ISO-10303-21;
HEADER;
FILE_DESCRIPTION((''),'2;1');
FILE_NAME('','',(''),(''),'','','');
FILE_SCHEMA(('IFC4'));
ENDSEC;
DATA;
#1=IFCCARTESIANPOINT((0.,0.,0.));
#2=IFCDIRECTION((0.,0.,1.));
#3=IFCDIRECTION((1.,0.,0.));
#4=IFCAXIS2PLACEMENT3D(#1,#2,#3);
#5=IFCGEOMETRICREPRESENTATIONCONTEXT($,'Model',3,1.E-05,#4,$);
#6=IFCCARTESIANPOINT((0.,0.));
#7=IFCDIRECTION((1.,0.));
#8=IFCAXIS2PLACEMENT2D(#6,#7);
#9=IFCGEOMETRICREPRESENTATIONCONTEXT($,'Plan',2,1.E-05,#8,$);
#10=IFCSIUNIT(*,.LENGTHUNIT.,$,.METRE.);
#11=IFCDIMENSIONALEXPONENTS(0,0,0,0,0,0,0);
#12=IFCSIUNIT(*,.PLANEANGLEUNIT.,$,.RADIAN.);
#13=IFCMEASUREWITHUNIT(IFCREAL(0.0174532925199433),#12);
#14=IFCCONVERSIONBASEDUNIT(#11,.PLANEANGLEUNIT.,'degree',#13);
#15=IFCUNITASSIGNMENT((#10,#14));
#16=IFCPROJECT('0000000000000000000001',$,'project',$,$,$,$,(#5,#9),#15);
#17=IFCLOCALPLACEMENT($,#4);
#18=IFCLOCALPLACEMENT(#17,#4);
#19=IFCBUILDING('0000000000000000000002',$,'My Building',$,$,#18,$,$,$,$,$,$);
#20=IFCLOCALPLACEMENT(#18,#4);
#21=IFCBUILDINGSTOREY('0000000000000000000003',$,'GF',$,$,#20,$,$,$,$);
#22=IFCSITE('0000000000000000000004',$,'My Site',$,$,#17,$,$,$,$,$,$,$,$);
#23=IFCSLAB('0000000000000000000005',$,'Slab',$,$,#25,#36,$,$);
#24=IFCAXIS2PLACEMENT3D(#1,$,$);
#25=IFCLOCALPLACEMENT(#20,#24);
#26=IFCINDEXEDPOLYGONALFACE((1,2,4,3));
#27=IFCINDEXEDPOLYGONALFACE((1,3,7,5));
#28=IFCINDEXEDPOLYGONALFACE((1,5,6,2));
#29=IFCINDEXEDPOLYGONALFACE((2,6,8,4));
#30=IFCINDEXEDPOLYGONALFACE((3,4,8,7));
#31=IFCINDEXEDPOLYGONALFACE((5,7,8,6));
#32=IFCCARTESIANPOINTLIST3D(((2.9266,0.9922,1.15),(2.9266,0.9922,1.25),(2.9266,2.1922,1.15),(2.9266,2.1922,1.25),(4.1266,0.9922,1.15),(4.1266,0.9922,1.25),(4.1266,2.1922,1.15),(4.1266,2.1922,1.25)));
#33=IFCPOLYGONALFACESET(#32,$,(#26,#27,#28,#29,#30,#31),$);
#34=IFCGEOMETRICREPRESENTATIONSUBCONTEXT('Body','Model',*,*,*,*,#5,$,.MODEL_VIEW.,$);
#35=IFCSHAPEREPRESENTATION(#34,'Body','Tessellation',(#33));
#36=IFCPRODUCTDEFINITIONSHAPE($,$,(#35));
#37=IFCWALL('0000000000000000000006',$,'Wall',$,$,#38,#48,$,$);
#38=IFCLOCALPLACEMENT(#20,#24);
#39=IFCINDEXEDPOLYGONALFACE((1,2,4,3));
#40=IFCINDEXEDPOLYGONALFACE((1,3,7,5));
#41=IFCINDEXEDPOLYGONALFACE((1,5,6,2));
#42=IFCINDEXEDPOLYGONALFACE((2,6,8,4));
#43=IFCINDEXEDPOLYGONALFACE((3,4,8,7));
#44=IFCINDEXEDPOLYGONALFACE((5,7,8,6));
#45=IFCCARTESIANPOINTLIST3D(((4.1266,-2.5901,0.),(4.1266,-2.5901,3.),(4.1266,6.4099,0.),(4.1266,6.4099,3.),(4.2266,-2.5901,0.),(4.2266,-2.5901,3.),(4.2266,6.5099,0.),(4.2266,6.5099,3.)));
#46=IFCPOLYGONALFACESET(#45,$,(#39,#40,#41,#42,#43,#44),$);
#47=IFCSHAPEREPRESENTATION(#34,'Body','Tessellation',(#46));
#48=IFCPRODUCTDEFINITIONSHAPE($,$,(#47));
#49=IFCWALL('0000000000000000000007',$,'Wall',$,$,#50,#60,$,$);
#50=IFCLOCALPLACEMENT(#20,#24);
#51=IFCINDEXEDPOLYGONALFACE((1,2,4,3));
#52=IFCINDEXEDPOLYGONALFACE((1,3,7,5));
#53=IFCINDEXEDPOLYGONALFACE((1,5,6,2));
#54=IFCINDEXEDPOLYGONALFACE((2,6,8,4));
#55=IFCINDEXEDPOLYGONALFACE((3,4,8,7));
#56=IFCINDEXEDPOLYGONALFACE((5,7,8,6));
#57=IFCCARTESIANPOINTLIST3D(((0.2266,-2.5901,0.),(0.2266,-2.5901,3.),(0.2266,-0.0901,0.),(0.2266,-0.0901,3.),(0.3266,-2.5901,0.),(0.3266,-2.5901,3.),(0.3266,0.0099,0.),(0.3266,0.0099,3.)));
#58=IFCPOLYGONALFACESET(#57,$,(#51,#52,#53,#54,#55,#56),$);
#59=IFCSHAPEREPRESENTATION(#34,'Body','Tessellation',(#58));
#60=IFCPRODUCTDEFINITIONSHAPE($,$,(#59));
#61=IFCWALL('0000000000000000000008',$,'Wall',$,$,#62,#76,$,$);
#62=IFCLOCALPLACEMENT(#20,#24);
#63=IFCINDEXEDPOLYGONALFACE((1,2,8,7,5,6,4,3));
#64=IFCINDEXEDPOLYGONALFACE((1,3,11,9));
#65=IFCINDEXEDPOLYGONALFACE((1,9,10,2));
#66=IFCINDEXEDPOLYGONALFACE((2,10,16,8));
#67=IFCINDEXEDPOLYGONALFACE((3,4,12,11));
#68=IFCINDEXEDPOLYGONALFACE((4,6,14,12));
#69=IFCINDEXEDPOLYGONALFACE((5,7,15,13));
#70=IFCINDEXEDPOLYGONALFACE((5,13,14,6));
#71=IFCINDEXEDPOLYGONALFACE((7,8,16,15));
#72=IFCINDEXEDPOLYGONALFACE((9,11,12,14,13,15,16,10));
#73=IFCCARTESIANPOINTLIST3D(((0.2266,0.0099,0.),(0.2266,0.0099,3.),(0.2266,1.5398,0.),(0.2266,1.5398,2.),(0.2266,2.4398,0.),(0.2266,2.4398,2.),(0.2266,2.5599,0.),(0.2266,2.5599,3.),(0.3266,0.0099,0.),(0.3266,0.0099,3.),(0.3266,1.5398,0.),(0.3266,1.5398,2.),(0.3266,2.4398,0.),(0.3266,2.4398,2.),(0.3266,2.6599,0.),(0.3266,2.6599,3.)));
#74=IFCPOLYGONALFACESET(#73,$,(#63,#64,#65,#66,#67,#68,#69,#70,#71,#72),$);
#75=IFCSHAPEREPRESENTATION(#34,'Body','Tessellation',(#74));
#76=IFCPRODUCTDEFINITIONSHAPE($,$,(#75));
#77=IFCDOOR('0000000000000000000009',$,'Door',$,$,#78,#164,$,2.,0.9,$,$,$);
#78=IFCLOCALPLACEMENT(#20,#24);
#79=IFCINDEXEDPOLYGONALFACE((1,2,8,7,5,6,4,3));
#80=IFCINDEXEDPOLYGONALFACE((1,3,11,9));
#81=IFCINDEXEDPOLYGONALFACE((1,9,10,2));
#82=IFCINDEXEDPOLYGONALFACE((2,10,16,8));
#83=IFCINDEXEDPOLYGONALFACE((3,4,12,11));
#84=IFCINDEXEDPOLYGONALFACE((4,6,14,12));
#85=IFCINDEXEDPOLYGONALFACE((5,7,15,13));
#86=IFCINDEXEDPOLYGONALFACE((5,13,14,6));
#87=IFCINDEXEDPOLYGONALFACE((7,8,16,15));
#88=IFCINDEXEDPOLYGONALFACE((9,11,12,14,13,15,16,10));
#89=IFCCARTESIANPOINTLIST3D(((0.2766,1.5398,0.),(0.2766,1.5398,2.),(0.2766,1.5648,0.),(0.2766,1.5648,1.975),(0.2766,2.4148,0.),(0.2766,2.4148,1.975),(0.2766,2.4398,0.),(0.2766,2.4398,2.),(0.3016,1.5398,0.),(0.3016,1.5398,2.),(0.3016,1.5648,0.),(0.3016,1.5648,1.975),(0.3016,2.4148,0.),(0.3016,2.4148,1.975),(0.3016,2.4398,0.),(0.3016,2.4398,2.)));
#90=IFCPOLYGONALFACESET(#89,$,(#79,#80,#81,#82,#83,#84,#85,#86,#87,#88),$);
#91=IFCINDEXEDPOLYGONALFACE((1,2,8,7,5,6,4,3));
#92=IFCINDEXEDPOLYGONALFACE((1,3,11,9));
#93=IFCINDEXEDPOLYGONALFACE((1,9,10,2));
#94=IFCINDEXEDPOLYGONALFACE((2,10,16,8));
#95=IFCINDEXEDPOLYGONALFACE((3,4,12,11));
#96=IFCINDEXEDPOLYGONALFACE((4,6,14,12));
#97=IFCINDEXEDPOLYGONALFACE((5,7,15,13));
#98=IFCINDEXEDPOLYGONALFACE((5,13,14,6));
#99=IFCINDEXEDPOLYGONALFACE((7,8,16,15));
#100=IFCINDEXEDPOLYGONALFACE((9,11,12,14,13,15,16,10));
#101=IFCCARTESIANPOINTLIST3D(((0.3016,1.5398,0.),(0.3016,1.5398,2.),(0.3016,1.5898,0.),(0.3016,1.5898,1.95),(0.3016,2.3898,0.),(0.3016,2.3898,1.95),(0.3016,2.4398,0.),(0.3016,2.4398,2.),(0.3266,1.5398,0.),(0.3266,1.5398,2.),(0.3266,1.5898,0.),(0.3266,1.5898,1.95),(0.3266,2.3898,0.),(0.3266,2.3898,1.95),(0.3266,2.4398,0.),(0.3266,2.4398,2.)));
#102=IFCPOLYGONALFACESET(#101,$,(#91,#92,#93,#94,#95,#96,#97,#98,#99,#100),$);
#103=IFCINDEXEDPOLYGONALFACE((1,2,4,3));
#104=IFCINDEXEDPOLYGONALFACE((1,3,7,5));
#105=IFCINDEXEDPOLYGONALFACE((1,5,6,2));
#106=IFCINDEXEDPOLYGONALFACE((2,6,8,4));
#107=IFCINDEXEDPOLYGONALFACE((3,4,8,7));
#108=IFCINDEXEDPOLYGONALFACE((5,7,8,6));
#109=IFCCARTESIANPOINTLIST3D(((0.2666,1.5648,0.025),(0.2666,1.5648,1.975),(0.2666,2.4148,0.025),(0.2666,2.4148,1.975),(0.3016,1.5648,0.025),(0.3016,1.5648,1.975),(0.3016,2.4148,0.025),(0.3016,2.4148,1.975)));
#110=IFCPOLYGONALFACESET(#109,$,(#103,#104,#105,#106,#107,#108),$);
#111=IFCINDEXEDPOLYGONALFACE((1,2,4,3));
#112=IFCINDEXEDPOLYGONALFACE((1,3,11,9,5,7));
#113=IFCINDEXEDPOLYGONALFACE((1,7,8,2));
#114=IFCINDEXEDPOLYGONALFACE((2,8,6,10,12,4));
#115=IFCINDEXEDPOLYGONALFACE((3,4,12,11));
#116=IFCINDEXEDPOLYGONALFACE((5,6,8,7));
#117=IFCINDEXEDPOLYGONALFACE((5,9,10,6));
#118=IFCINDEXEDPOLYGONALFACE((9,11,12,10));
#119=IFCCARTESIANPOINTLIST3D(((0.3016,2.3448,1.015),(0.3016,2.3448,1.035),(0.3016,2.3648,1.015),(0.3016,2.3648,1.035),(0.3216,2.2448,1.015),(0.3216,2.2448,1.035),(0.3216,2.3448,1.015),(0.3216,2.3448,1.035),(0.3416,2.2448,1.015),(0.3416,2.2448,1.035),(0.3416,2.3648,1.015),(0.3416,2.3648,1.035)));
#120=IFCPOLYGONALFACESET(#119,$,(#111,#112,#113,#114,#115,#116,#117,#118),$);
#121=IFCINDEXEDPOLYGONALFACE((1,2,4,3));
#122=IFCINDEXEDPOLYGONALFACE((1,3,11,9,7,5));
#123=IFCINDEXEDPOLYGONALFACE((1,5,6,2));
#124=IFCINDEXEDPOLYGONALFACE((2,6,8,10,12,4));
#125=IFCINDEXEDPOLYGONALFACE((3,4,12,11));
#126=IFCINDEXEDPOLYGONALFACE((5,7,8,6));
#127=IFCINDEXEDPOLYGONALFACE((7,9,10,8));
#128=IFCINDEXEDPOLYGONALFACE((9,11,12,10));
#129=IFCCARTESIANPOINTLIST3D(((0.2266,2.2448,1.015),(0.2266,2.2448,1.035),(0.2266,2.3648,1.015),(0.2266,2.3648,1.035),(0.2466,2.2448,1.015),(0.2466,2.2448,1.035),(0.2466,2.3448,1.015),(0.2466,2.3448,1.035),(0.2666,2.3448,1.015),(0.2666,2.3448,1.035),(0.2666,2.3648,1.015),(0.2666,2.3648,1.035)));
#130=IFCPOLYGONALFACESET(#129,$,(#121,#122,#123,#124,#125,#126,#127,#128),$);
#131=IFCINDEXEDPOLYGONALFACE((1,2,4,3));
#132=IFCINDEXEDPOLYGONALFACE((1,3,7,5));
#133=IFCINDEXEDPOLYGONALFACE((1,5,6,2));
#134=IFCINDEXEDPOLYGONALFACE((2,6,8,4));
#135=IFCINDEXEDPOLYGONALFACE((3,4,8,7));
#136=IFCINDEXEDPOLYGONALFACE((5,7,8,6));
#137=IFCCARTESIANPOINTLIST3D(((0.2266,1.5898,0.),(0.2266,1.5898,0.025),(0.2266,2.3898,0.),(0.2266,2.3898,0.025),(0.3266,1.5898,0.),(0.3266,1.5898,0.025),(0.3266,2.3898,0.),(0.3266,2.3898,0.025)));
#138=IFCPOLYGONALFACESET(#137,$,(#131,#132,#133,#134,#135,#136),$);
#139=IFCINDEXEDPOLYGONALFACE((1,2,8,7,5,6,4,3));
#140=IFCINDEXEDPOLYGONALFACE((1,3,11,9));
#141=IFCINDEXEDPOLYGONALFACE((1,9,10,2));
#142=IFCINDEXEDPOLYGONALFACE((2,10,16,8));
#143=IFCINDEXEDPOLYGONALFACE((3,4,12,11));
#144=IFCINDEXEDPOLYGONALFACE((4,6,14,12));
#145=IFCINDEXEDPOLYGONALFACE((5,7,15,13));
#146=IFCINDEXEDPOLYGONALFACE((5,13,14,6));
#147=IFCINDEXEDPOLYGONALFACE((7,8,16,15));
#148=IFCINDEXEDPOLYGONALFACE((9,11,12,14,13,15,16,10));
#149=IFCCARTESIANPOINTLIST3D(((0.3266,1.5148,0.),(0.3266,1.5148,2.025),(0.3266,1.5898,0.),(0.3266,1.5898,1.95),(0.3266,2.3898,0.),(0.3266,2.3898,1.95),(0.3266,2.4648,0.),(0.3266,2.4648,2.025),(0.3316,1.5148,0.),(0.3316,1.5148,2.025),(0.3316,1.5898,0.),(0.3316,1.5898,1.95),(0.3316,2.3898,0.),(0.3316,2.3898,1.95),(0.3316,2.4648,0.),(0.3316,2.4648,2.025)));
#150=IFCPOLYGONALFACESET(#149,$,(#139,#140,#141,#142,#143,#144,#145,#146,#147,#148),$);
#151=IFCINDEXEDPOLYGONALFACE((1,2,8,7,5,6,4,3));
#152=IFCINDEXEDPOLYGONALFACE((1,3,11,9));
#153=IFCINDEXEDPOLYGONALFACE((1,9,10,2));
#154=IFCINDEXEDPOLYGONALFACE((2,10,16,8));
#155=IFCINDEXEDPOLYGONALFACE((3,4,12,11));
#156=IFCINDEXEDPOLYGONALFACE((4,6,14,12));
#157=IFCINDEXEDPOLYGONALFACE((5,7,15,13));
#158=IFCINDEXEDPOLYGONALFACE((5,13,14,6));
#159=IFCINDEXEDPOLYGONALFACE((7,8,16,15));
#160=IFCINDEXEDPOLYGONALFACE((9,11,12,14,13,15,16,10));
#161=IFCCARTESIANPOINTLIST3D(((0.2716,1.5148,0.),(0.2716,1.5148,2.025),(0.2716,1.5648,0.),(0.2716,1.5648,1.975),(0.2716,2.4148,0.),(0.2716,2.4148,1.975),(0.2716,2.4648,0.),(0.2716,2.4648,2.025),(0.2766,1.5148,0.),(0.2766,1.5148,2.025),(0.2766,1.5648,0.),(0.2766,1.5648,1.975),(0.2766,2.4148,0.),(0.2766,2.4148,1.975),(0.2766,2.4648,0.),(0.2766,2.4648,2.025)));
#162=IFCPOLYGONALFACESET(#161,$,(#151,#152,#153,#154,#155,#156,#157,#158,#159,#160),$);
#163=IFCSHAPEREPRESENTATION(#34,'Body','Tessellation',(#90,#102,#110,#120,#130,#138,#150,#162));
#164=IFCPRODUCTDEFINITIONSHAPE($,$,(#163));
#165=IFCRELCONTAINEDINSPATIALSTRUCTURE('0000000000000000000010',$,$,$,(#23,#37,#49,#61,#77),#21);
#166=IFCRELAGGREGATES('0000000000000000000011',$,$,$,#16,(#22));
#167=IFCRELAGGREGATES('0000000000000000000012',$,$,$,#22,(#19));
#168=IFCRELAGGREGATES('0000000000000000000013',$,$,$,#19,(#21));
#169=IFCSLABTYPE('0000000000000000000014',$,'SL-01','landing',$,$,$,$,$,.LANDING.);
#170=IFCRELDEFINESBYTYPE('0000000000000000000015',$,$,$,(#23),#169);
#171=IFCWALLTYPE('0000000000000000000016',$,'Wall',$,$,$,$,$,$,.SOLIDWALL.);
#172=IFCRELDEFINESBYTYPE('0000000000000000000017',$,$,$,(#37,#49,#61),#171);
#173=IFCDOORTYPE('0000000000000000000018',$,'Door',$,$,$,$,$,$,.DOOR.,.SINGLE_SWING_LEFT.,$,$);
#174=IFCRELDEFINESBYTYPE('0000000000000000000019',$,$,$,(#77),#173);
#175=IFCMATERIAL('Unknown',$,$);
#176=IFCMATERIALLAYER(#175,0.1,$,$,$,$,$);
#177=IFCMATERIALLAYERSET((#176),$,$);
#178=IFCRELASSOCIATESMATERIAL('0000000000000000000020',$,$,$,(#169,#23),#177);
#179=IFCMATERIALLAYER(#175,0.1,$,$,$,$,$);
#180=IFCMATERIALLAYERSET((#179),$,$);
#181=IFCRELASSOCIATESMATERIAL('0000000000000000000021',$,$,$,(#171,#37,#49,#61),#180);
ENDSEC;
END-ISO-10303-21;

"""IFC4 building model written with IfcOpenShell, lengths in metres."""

from ifc_helpers import new_model, entity, si_unit, converted_unit, frame, origin_with_axes, origin_2d_with_axis, place, context, subcontext, project, spatial, line, indexed_curve, outline, extrude, shape, source, transform, mapped, material, layer, layer_set, layer_usage, type_object, type_shapes, element, fill, save


model = new_model("IFC4")

# Units and contexts
model_context = context("Model", 3, precision=1e-05, world=origin_with_axes())
plan_context = context("Plan", 2, precision=1e-05, world=origin_2d_with_axis())
body_context_1 = subcontext(model_context, "Body", "Model", "MODEL_VIEW")
body_context_2 = subcontext(plan_context, "Body", "Plan", "PLAN_VIEW")
ifc_project = project(units=[si_unit("LENGTHUNIT", "METRE"), converted_unit("PLANEANGLEUNIT", "degree", entity("IfcReal", 0.0174532925199433), si_unit("PLANEANGLEUNIT", "RADIAN"), dimensions=[0, 0, 0, 0, 0, 0, 0])], contexts=[model_context, plan_context])

# Site, building, storey
site_placement = place(None, origin_with_axes())
site = spatial("IfcSite", under=ifc_project, at=site_placement, Name="My Site")
building_placement = place(site_placement, origin_with_axes())
building = spatial("IfcBuilding", under=site, at=building_placement, Name="My Building")
storey_placement = place(building_placement, origin_with_axes())
storey = spatial("IfcBuildingStorey", under=building, at=storey_placement, Name="GF")

# Shared definitions
ifc_material = material(Name="Unknown")

# Slab
ifc_layer_1 = layer(ifc_material, 0.1)
ifc_layer_set_1 = layer_set([ifc_layer_1])
ifc_layer_usage_1 = layer_usage(ifc_layer_set_1, "AXIS3", "POSITIVE", -0.1)
slab_type_1 = type_object("IfcSlabType", Name="SL-01", Description="landing", PredefinedType="LANDING", material=ifc_layer_set_1)
slab_1_placement = place(storey_placement, frame((2.9266, 2.1922, 1.25), z_axis=(0.0, 0.0, 1.0), x_axis=(1.0, 0.0, 0.0)))
element("IfcSlab", 1, at=slab_1_placement, inside=storey, type_object=slab_type_1, material=ifc_layer_usage_1, Name="Slab", context=body_context_1, shape_type="SweptSolid", body=[
    extrude(outline(indexed_curve([(0.0, 0.0), (0.0, -1.2), (1.2, -1.2), (1.2, 0.0), (0.0, 0.0)])), frame((0.0, 0.0, -0.1), z_axis=(0.0, 0.0, 1.0), x_axis=(1.0, 0.0, 0.0)), (0.0, 0.0, 1.0), 0.1),
])

# Shared definitions
ifc_layer_2 = layer(ifc_material, 0.1)
ifc_layer_set_2 = layer_set([ifc_layer_2])
wall_type = type_object("IfcWallType", Name="Wall", PredefinedType="SOLIDWALL", material=ifc_layer_set_2)
shared_shape_1 = source(origin_with_axes(), body_context_1, "Body", "SweptSolid", [
    extrude(outline(indexed_curve([(0.0, 0.0), (0.9, 0.0), (0.9, 2.0), (0.0, 2.0)], segments=[line(1, 2, 3, 4, 1)])), frame((0.0, -0.6, 0.0), z_axis=(0.0, -1.0, 0.0), x_axis=(1.0, 0.0, 0.0)), (0.0, 0.0, -1.0), 1.2),
])
door_type = type_object("IfcDoorType", Name="Door", OperationType="SINGLE_SWING_LEFT", PredefinedType="DOOR")
shared_shape_2 = source(origin_with_axes(), body_context_1, "Body", "SweptSolid", [
    extrude(outline(indexed_curve([(0.0, 0.0), (0.0, 2.0), (0.9, 2.0), (0.9, 0.0), (0.875, 0.0), (0.875, 1.975), (0.025, 1.975), (0.025, 0.0)], segments=[line(1, 2, 3, 4, 5, 6, 7, 8, 1)])), frame((0.0, 0.025, 0.0), z_axis=(0.0, -1.0, 0.0), x_axis=(1.0, 0.0, 0.0)), (0.0, 0.0, -1.0), 0.025),
    extrude(outline(indexed_curve([(0.0, 0.0), (0.0, 2.0), (0.9, 2.0), (0.9, 0.0), (0.85, 0.0), (0.85, 1.95), (0.05, 1.95), (0.05, 0.0)], segments=[line(1, 2, 3, 4, 5, 6, 7, 8, 1)])), frame((0.0, 0.0, 0.0), z_axis=(0.0, -1.0, 0.0), x_axis=(1.0, 0.0, 0.0)), (0.0, 0.0, -1.0), 0.025),
    extrude(outline(indexed_curve([(0.0, 0.0), (0.85, 0.0), (0.85, 0.035), (0.0, 0.035)], segments=[line(1, 2, 3, 4, 1)])), frame((0.025, 0.025, 0.025), z_axis=(0.0, 0.0, 1.0), x_axis=(1.0, 0.0, 0.0)), (0.0, 0.0, 1.0), 1.95),
    extrude(outline(indexed_curve([(0.0, 0.0), (0.0, -0.04), (-0.12, -0.04), (-0.12, -0.02), (-0.02, -0.02), (-0.02, 0.0)], segments=[line(1, 2, 3, 4, 5, 6, 1)])), frame((0.825, 0.025, 1.015), z_axis=(0.0, 0.0, 1.0), x_axis=(1.0, 0.0, 0.0)), (0.0, 0.0, 1.0), 0.02),
    extrude(outline(indexed_curve([(0.0, 0.0), (0.0, 0.04), (-0.12, 0.04), (-0.12, 0.02), (-0.02, 0.02), (-0.02, 0.0)], segments=[line(1, 2, 3, 4, 5, 6, 1)])), frame((0.825, 0.06, 1.015), z_axis=(0.0, 0.0, 1.0), x_axis=(1.0, 0.0, 0.0)), (0.0, 0.0, 1.0), 0.02),
    extrude(outline(indexed_curve([(0.0, 0.0), (0.8, 0.0), (0.8, 0.1), (0.0, 0.1)], segments=[line(1, 2, 3, 4, 1)])), frame((0.05, 0.0, 0.0), z_axis=(0.0, 0.0, 1.0), x_axis=(1.0, 0.0, 0.0)), (0.0, 0.0, 1.0), 0.025),
    extrude(outline(indexed_curve([(0.0, 0.0), (0.0, 2.025), (0.95, 2.025), (0.95, 0.0), (0.875, 0.0), (0.875, 1.95), (0.075, 1.95), (0.075, 0.0)], segments=[line(1, 2, 3, 4, 5, 6, 7, 8, 1)])), frame((-0.025, -0.005, 0.0), z_axis=(0.0, -1.0, 0.0), x_axis=(1.0, 0.0, 0.0)), (0.0, 0.0, -1.0), 0.005),
    extrude(outline(indexed_curve([(0.0, 0.0), (0.0, 2.025), (0.95, 2.025), (0.95, 0.0), (0.9, 0.0), (0.9, 1.975), (0.05, 1.975), (0.05, 0.0)], segments=[line(1, 2, 3, 4, 5, 6, 7, 8, 1)])), frame((-0.025, 0.05, 0.0), z_axis=(0.0, -1.0, 0.0), x_axis=(1.0, 0.0, 0.0)), (0.0, 0.0, -1.0), 0.005),
])
shared_shape_3 = source(origin_with_axes(), body_context_2, "Body", "Curve2D", [
    entity("IfcIndexedPolyCurve", entity("IfcCartesianPointList2D", [[0.0, 0.0], [0.0, 0.05], [0.025, 0.05], [0.025, 0.025], [0.05, 0.025], [0.05, 0.0]]), [entity("IfcLineIndex", [1, 2, 3, 4, 5, 6, 1])]),
    entity("IfcIndexedPolyCurve", entity("IfcCartesianPointList2D", [[0.9, 0.0], [0.9, 0.05], [0.875, 0.05], [0.875, 0.025], [0.85, 0.025], [0.85, 0.0]]), [entity("IfcLineIndex", [1, 2, 3, 4, 5, 6, 1])]),
    entity("IfcTrimmedCurve", entity("IfcEllipse", entity("IfcAxis2Placement2D", entity("IfcCartesianPoint", [0.06, 0.05]), entity("IfcDirection", [1.0, 0.0])), 0.815, 0.85), [entity("IfcCartesianPoint", [0.875, 0.05])], [entity("IfcCartesianPoint", [0.06, 0.9])], True, "CARTESIAN"),
    entity("IfcIndexedPolyCurve", entity("IfcCartesianPointList2D", [[0.025, 0.05], [0.06, 0.05], [0.06, 0.9], [0.025, 0.9]]), [entity("IfcLineIndex", [1, 2, 3, 4, 1])]),
])
type_shapes(door_type, [shared_shape_2, shared_shape_3])

# Walls
ifc_layer_usage_2 = layer_usage(ifc_layer_set_2, "AXIS2", "POSITIVE", 0.0)
wall_1_placement = place(storey_placement, frame((4.2266, -2.5901, 0.0), z_axis=(0.0, 0.0, 1.0), x_axis=(0.0, 1.0, 0.0)))
element("IfcWall", 2, at=wall_1_placement, inside=storey, type_object=wall_type, material=ifc_layer_usage_2, Name="Wall", context=body_context_1, shape_type="SweptSolid", body=[
    extrude(outline(indexed_curve([(0.0, 0.0), (0.0, 0.1), (9.0, 0.1), (9.1, 0.0)], segments=[line(1, 2, 3, 4, 1)])), origin_with_axes(), (0.0, 0.0, 1.0), 3.0),
])
ifc_layer_usage_3 = layer_usage(ifc_layer_set_2, "AXIS2", "POSITIVE", 0.0)
wall_2_placement = place(storey_placement, frame((0.2266, -0.0901, 0.0), z_axis=(0.0, 0.0, 1.0), x_axis=(0.0, -1.0, 0.0)))
element("IfcWall", 3, at=wall_2_placement, inside=storey, type_object=wall_type, material=ifc_layer_usage_3, Name="Wall", context=body_context_1, shape_type="SweptSolid", body=[
    extrude(outline(indexed_curve([(0.0, 0.0), (-0.1, 0.1), (2.5, 0.1), (2.5, 0.0)], segments=[line(1, 2, 3, 4, 1)])), origin_with_axes(), (0.0, 0.0, 1.0), 3.0),
])

# Wall, opening, door
ifc_layer_usage_4 = layer_usage(ifc_layer_set_2, "AXIS2", "POSITIVE", 0.0)
wall_3_placement = place(storey_placement, frame((0.3266, 0.0099, 0.0), z_axis=(0.0, 0.0, 1.0), x_axis=(0.0, 1.0, 0.0)))
wall_3 = element("IfcWall", 4, at=wall_3_placement, inside=storey, type_object=wall_type, material=ifc_layer_usage_4, Name="Wall", context=body_context_1, shape_type="SweptSolid", body=[
    extrude(outline(indexed_curve([(0.0, 0.0), (0.0, 0.1), (2.55, 0.1), (2.65, 0.0)], segments=[line(1, 2, 3, 4, 1)])), origin_with_axes(), (0.0, 0.0, 1.0), 3.0),
])
opening_1_placement = place(wall_3_placement, frame((1.5299, 0.0, 0.0), z_axis=(0.0, 0.0, 1.0), x_axis=(1.0, 0.0, 0.0)))
opening_1 = element("IfcOpeningElement", 5, at=opening_1_placement, cuts=wall_3, PredefinedType="OPENING", context=body_context_1, shape_type="MappedRepresentation", body=[
    mapped(shared_shape_1, transform((0.0, 0.0, 0.0), x_axis=(1.0, 0.0, 0.0), y_axis=(0.0, 1.0, 0.0), z_axis=(0.0, 0.0, 1.0), scale=1.0)),
])
door_1_placement = place(opening_1_placement, frame((0.0, 0.0, 0.0), z_axis=(0.0, 0.0, 1.0), x_axis=(1.0, 0.0, 0.0)))
door_1 = element("IfcDoor", 6, at=door_1_placement, inside=storey, type_object=door_type, Name="Door", OverallHeight=2.0, OverallWidth=0.9, shapes=[
    shape(body_context_1, "Body", "MappedRepresentation", [mapped(shared_shape_2, transform((0.0, 0.0, 0.0), x_axis=(1.0, 0.0, 0.0), y_axis=(0.0, 1.0, 0.0), z_axis=(0.0, 0.0, 1.0), scale=1.0))]),
    shape(body_context_2, "Body", "MappedRepresentation", [mapped(shared_shape_3, transform((0.0, 0.0, 0.0), x_axis=(1.0, 0.0, 0.0), y_axis=(0.0, 1.0, 0.0), z_axis=(0.0, 0.0, 1.0), scale=1.0))]),
])
fill(opening_1, door_1)

save(model, "model.ifc")
